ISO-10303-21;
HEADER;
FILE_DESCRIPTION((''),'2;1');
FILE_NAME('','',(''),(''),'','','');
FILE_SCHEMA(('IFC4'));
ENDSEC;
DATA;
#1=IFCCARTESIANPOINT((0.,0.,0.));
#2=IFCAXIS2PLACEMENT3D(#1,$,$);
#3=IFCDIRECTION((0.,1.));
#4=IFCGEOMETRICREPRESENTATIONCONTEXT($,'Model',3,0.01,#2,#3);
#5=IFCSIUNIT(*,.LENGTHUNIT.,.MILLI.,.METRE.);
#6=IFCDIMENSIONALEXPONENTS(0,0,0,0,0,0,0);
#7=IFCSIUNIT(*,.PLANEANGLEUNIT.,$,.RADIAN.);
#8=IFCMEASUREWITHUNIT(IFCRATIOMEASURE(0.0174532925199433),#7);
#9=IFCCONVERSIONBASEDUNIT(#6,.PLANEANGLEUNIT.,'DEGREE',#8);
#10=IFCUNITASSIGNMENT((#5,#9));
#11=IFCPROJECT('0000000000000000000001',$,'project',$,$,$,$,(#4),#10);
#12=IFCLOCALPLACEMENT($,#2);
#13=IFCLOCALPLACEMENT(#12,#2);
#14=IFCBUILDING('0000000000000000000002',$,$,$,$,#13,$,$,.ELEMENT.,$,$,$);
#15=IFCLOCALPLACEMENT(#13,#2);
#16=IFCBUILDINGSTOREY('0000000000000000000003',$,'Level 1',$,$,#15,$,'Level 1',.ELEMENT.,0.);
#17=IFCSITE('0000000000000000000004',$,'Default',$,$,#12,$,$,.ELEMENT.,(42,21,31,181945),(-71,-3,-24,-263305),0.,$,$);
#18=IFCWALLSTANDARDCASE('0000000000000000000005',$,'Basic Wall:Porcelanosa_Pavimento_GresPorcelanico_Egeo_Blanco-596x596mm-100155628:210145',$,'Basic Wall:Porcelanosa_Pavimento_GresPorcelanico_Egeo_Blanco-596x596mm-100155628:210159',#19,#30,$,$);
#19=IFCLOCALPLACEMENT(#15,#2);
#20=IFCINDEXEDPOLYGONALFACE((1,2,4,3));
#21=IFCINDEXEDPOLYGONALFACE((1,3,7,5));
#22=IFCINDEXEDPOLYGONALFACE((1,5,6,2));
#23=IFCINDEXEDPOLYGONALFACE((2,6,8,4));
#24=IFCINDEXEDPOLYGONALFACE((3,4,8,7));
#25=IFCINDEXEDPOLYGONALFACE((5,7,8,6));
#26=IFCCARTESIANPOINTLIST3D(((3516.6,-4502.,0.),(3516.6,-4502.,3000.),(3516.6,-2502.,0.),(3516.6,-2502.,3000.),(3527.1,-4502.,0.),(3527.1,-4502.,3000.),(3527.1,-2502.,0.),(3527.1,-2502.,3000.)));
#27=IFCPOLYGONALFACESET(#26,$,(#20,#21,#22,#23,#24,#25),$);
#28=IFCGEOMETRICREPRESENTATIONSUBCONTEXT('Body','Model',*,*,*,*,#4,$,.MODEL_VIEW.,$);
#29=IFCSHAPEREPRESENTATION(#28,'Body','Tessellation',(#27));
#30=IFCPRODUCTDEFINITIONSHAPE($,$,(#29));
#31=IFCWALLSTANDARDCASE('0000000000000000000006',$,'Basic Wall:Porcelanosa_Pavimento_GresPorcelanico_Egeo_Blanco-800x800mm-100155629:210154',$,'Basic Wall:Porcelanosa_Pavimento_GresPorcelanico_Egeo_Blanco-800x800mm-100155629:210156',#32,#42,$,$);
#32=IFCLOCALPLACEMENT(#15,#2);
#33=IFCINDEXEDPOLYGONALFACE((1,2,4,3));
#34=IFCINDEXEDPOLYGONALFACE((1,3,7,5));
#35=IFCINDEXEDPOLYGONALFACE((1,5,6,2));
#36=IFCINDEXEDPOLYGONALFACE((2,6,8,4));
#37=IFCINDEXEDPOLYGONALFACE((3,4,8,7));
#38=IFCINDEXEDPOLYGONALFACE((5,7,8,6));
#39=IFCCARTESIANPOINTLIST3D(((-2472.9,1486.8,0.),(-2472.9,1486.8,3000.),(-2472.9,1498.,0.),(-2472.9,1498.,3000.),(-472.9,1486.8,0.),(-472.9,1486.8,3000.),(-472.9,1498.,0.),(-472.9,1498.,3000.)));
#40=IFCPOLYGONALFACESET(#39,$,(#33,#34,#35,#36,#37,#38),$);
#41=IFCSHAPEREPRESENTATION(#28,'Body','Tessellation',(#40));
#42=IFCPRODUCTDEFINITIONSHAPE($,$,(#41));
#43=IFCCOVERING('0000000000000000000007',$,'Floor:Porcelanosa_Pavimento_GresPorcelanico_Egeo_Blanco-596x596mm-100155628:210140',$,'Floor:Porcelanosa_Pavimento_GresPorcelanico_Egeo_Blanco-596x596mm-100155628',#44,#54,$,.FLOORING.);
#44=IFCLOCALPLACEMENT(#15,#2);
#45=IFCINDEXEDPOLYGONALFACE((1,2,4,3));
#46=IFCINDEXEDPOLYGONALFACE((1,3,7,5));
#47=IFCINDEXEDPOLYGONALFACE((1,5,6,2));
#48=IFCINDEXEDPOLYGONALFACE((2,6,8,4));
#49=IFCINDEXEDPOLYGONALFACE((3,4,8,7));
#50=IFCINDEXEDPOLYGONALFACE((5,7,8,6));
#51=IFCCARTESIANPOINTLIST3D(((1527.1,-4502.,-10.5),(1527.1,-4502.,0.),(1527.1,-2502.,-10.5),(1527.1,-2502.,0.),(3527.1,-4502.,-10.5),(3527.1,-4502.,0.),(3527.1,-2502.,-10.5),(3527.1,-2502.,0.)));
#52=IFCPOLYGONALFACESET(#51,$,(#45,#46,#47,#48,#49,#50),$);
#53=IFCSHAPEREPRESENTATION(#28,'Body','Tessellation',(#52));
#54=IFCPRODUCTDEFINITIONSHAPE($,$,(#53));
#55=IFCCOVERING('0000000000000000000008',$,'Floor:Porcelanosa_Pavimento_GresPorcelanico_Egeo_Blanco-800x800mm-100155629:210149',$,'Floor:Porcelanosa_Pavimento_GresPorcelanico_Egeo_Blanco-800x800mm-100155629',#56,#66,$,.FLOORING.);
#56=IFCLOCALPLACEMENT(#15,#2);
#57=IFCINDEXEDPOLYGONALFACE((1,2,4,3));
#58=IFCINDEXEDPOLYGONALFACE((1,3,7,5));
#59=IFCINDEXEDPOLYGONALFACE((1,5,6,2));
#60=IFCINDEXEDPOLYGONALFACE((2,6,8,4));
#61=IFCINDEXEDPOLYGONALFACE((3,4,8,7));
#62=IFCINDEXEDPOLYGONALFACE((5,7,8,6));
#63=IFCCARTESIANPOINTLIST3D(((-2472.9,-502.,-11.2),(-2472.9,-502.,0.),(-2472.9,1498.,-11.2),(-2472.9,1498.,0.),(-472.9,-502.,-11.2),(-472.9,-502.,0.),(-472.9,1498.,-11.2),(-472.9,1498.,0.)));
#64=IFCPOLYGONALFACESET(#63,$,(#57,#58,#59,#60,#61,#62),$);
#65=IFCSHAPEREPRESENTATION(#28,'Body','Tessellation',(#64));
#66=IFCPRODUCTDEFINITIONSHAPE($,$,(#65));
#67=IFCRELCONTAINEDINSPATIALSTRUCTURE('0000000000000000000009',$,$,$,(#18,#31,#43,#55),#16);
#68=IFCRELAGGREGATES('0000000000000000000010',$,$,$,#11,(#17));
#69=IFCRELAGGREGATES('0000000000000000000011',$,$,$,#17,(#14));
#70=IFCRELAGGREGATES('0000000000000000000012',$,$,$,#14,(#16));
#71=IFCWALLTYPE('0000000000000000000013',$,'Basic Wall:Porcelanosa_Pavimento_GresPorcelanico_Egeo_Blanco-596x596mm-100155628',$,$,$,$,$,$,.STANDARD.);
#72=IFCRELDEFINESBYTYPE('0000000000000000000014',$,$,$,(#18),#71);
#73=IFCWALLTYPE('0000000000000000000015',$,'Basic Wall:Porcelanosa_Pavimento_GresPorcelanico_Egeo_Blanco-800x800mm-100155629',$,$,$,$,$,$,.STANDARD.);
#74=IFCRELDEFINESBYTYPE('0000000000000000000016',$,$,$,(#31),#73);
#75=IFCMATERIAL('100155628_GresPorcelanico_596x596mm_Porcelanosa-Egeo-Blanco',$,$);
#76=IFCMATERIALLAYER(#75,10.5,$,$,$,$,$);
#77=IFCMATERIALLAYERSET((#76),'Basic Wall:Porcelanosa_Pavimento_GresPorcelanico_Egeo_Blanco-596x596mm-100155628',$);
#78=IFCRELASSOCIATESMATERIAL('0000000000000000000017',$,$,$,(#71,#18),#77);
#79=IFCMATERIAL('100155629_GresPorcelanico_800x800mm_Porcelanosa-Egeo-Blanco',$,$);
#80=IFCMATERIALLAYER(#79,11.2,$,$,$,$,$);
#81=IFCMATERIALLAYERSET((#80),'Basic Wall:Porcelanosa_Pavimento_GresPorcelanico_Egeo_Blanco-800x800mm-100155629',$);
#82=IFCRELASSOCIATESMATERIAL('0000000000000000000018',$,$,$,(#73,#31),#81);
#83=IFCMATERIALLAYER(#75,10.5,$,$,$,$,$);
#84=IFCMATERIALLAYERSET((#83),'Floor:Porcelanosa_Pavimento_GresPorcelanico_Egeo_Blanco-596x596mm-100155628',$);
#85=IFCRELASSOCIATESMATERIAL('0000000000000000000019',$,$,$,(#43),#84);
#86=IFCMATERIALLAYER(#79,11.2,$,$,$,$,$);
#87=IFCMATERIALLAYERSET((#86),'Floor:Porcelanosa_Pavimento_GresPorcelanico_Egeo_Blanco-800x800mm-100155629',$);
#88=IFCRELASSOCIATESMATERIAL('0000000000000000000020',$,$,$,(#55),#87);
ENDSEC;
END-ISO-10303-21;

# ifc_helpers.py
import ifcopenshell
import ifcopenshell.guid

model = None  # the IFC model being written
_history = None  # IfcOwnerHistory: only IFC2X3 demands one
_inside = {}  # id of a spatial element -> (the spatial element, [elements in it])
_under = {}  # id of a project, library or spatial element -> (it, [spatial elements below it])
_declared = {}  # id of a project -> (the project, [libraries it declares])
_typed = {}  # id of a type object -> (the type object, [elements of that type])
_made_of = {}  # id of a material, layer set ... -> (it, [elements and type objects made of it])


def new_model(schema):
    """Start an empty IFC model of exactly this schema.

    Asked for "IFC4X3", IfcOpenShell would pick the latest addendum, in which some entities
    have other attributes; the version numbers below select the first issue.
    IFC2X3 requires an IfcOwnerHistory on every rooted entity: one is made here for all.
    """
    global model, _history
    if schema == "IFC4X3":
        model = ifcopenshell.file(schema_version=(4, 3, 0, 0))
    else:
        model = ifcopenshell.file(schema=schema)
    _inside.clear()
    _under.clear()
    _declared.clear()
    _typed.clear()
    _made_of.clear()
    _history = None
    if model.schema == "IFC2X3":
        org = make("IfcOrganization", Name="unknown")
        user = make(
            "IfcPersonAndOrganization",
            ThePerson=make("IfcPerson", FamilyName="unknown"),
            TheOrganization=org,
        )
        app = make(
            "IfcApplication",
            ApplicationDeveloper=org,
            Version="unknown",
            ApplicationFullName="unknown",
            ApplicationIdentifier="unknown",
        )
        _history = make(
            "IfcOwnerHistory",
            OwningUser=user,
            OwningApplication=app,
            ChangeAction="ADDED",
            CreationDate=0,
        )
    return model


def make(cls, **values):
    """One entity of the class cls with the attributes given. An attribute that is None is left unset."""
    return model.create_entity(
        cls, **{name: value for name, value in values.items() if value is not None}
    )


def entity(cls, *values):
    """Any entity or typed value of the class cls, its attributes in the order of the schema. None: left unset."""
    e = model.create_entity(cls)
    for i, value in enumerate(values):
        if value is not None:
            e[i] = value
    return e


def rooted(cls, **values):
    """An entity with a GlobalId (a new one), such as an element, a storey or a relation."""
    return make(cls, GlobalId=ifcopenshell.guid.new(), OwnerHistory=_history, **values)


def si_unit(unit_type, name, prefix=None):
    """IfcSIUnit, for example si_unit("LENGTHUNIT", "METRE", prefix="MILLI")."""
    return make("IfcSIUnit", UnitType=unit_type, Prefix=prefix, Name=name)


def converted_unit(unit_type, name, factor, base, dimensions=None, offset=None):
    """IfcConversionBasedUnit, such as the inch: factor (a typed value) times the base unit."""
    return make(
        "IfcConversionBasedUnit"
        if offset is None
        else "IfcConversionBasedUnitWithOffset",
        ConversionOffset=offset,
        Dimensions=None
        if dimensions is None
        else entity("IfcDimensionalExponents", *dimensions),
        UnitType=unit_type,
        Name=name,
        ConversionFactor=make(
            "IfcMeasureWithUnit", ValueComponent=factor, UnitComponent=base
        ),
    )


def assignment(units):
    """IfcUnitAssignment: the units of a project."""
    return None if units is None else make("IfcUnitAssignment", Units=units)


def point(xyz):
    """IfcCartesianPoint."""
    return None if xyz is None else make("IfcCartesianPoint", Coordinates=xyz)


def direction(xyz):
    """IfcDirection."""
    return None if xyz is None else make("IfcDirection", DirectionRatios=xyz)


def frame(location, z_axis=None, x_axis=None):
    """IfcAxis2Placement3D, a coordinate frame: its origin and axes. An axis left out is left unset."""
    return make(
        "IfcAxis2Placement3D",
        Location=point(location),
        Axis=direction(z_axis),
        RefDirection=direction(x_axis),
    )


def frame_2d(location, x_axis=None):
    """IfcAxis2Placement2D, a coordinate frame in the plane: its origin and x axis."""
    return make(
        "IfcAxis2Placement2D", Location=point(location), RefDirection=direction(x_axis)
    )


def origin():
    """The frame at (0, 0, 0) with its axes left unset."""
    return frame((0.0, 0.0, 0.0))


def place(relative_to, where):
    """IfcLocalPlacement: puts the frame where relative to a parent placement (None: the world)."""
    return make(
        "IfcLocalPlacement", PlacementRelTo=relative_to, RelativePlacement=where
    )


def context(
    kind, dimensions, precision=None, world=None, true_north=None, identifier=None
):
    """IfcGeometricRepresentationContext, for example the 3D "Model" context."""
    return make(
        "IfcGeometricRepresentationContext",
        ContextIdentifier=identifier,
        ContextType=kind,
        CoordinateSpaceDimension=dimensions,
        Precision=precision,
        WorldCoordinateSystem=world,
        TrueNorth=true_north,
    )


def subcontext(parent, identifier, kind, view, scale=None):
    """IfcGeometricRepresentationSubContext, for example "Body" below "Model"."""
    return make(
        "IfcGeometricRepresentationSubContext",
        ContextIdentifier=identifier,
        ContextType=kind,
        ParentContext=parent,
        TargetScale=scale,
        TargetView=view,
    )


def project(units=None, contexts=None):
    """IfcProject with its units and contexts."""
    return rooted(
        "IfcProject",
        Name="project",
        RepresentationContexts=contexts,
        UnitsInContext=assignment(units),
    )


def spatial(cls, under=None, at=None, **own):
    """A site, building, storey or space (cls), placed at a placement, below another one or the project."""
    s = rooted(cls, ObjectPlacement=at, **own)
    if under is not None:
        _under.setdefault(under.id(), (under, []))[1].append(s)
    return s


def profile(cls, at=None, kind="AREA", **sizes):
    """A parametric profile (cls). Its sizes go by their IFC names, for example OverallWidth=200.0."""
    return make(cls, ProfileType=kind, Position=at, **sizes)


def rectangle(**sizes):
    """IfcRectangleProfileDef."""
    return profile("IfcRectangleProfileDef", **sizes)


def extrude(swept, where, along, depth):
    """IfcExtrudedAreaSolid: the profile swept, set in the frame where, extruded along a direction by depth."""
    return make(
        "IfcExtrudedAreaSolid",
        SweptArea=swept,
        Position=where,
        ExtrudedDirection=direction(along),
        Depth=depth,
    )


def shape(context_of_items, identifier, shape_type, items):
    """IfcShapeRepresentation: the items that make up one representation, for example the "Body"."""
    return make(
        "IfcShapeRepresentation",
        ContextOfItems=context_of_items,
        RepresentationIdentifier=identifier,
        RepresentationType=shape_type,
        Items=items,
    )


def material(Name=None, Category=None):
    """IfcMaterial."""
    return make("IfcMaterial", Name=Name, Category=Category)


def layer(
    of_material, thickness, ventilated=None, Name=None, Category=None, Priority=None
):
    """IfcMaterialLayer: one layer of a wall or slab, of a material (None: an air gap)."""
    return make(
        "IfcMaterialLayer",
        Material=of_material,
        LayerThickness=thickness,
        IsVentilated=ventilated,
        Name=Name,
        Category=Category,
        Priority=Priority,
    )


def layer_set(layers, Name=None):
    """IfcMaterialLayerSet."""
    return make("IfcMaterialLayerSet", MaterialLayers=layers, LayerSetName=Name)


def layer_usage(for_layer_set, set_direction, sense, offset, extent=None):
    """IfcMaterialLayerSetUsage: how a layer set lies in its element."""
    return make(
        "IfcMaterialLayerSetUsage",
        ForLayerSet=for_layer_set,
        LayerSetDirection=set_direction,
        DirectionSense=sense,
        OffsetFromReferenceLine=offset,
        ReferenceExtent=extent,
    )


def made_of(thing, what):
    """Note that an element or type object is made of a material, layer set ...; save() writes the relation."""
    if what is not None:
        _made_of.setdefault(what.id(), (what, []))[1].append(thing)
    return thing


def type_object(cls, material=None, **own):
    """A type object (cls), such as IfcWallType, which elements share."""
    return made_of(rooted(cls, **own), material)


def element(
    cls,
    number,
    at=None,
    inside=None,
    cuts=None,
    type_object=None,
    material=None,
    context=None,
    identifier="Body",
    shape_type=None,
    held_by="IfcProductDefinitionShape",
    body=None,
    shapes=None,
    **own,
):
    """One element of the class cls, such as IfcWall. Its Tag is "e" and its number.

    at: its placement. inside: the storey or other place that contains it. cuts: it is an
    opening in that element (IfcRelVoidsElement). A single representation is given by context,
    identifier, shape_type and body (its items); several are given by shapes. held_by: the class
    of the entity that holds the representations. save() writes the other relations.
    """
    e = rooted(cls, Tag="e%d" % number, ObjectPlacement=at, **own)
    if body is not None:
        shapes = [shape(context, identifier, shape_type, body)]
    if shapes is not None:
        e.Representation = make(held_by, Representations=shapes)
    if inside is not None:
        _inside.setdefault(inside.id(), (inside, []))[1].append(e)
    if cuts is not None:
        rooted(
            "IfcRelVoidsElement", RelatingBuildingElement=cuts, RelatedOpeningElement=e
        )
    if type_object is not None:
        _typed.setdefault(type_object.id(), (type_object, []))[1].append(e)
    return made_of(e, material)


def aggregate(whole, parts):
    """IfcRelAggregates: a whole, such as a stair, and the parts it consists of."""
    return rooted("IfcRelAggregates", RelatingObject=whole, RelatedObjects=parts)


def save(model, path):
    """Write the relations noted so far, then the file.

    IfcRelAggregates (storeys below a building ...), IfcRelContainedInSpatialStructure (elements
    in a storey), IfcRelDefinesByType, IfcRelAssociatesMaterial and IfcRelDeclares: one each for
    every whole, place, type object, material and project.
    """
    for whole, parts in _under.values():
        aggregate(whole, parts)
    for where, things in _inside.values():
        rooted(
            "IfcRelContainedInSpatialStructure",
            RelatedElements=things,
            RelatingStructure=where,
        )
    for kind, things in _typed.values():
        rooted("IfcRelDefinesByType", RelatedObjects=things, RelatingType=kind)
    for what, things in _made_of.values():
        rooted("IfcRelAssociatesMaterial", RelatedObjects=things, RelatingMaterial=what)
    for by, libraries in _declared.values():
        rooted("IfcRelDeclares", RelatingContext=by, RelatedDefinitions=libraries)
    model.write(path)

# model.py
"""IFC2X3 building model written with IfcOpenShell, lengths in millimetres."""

from ifc_helpers import new_model, entity, si_unit, converted_unit, direction, frame, frame_2d, origin, place, context, subcontext, project, spatial, rectangle, extrude, material, layer, layer_set, layer_usage, type_object, element, save


model = new_model("IFC2X3")

# Units and contexts
model_context = context("Model", 3, precision=0.01, world=origin(), true_north=direction((0.0, 1.0)))
body_context = subcontext(model_context, "Body", "Model", "MODEL_VIEW")
ifc_project = project(units=[si_unit("LENGTHUNIT", "METRE", prefix="MILLI"), converted_unit("PLANEANGLEUNIT", "DEGREE", entity("IfcRatioMeasure", 0.0174532925199433), si_unit("PLANEANGLEUNIT", "RADIAN"), dimensions=[0, 0, 0, 0, 0, 0, 0])], contexts=[model_context])

# Site, building, storey
site_placement = place(None, origin())
site = spatial("IfcSite", under=ifc_project, at=site_placement, Name="Default", CompositionType="ELEMENT", RefLatitude=(42, 21, 31, 181945), RefLongitude=(-71, -3, -24, -263305), RefElevation=0.0)
building_placement = place(site_placement, origin())
building = spatial("IfcBuilding", under=site, at=building_placement, CompositionType="ELEMENT")
storey_placement = place(building_placement, origin())
storey = spatial("IfcBuildingStorey", under=building, at=storey_placement, Name="Level 1", LongName="Level 1", CompositionType="ELEMENT", Elevation=0.0)

# Walls
ifc_material_1 = material(Name="100155628_GresPorcelanico_596x596mm_Porcelanosa-Egeo-Blanco")
ifc_layer_1 = layer(ifc_material_1, 10.5)
ifc_layer_set_1 = layer_set([ifc_layer_1], Name="Basic Wall:Porcelanosa_Pavimento_GresPorcelanico_Egeo_Blanco-596x596mm-100155628")
ifc_layer_usage_1 = layer_usage(ifc_layer_set_1, "AXIS2", "POSITIVE", -5.2)
wall_type_1 = type_object("IfcWallType", Name="Basic Wall:Porcelanosa_Pavimento_GresPorcelanico_Egeo_Blanco-596x596mm-100155628", PredefinedType="STANDARD", material=ifc_layer_set_1)
wall_1_placement = place(storey_placement, frame((3521.8, -2502.0, 0.0), z_axis=(0.0, 0.0, 1.0), x_axis=(0.0, -1.0, 0.0)))
element("IfcWallStandardCase", 1, at=wall_1_placement, inside=storey, type_object=wall_type_1, material=ifc_layer_usage_1, Name="Basic Wall:Porcelanosa_Pavimento_GresPorcelanico_Egeo_Blanco-596x596mm-100155628:210145", ObjectType="Basic Wall:Porcelanosa_Pavimento_GresPorcelanico_Egeo_Blanco-596x596mm-100155628:210159", context=body_context, shape_type="SweptSolid", body=[
    extrude(rectangle(XDim=2000.0, YDim=10.5, at=frame_2d((1000.0, 0.0), x_axis=(-1.0, 0.0))), origin(), (0.0, 0.0, 1.0), 3000.0),
])
ifc_material_2 = material(Name="100155629_GresPorcelanico_800x800mm_Porcelanosa-Egeo-Blanco")
ifc_layer_2 = layer(ifc_material_2, 11.2)
ifc_layer_set_2 = layer_set([ifc_layer_2], Name="Basic Wall:Porcelanosa_Pavimento_GresPorcelanico_Egeo_Blanco-800x800mm-100155629")
ifc_layer_usage_2 = layer_usage(ifc_layer_set_2, "AXIS2", "POSITIVE", -5.6)
wall_type_2 = type_object("IfcWallType", Name="Basic Wall:Porcelanosa_Pavimento_GresPorcelanico_Egeo_Blanco-800x800mm-100155629", PredefinedType="STANDARD", material=ifc_layer_set_2)
wall_2_placement = place(storey_placement, frame((-2472.9, 1492.4, 0.0)))
element("IfcWallStandardCase", 2, at=wall_2_placement, inside=storey, type_object=wall_type_2, material=ifc_layer_usage_2, Name="Basic Wall:Porcelanosa_Pavimento_GresPorcelanico_Egeo_Blanco-800x800mm-100155629:210154", ObjectType="Basic Wall:Porcelanosa_Pavimento_GresPorcelanico_Egeo_Blanco-800x800mm-100155629:210156", context=body_context, shape_type="SweptSolid", body=[
    extrude(rectangle(XDim=2000.0, YDim=11.2, at=frame_2d((1000.0, 0.0), x_axis=(-1.0, 0.0))), origin(), (0.0, 0.0, 1.0), 3000.0),
])

# Coverings
ifc_layer_3 = layer(ifc_material_1, 10.5)
ifc_layer_set_3 = layer_set([ifc_layer_3], Name="Floor:Porcelanosa_Pavimento_GresPorcelanico_Egeo_Blanco-596x596mm-100155628")
ifc_layer_usage_3 = layer_usage(ifc_layer_set_3, "AXIS3", "POSITIVE", 0.0)
covering_1_placement = place(storey_placement, origin())
element("IfcCovering", 3, at=covering_1_placement, inside=storey, material=ifc_layer_usage_3, Name="Floor:Porcelanosa_Pavimento_GresPorcelanico_Egeo_Blanco-596x596mm-100155628:210140", ObjectType="Floor:Porcelanosa_Pavimento_GresPorcelanico_Egeo_Blanco-596x596mm-100155628", PredefinedType="FLOORING", context=body_context, shape_type="SweptSolid", body=[
    extrude(rectangle(XDim=2000.0, YDim=2000.0, at=frame_2d((0.0, 0.0), x_axis=(1.0, 0.0))), frame((2527.1, -3502.0, 0.0), z_axis=(0.0, 0.0, -1.0), x_axis=(0.0, 1.0, 0.0)), (0.0, 0.0, 1.0), 10.5),
])
ifc_layer_4 = layer(ifc_material_2, 11.2)
ifc_layer_set_4 = layer_set([ifc_layer_4], Name="Floor:Porcelanosa_Pavimento_GresPorcelanico_Egeo_Blanco-800x800mm-100155629")
ifc_layer_usage_4 = layer_usage(ifc_layer_set_4, "AXIS3", "POSITIVE", 0.0)
covering_2_placement = place(storey_placement, origin())
element("IfcCovering", 4, at=covering_2_placement, inside=storey, material=ifc_layer_usage_4, Name="Floor:Porcelanosa_Pavimento_GresPorcelanico_Egeo_Blanco-800x800mm-100155629:210149", ObjectType="Floor:Porcelanosa_Pavimento_GresPorcelanico_Egeo_Blanco-800x800mm-100155629", PredefinedType="FLOORING", context=body_context, shape_type="SweptSolid", body=[
    extrude(rectangle(XDim=2000.0, YDim=2000.0, at=frame_2d((0.0, 0.0), x_axis=(1.0, 0.0))), frame((-1472.9, 498.0, 0.0), z_axis=(0.0, 0.0, -1.0), x_axis=(0.0, 1.0, 0.0)), (0.0, 0.0, 1.0), 11.2),
])

save(model, "model.ifc")
